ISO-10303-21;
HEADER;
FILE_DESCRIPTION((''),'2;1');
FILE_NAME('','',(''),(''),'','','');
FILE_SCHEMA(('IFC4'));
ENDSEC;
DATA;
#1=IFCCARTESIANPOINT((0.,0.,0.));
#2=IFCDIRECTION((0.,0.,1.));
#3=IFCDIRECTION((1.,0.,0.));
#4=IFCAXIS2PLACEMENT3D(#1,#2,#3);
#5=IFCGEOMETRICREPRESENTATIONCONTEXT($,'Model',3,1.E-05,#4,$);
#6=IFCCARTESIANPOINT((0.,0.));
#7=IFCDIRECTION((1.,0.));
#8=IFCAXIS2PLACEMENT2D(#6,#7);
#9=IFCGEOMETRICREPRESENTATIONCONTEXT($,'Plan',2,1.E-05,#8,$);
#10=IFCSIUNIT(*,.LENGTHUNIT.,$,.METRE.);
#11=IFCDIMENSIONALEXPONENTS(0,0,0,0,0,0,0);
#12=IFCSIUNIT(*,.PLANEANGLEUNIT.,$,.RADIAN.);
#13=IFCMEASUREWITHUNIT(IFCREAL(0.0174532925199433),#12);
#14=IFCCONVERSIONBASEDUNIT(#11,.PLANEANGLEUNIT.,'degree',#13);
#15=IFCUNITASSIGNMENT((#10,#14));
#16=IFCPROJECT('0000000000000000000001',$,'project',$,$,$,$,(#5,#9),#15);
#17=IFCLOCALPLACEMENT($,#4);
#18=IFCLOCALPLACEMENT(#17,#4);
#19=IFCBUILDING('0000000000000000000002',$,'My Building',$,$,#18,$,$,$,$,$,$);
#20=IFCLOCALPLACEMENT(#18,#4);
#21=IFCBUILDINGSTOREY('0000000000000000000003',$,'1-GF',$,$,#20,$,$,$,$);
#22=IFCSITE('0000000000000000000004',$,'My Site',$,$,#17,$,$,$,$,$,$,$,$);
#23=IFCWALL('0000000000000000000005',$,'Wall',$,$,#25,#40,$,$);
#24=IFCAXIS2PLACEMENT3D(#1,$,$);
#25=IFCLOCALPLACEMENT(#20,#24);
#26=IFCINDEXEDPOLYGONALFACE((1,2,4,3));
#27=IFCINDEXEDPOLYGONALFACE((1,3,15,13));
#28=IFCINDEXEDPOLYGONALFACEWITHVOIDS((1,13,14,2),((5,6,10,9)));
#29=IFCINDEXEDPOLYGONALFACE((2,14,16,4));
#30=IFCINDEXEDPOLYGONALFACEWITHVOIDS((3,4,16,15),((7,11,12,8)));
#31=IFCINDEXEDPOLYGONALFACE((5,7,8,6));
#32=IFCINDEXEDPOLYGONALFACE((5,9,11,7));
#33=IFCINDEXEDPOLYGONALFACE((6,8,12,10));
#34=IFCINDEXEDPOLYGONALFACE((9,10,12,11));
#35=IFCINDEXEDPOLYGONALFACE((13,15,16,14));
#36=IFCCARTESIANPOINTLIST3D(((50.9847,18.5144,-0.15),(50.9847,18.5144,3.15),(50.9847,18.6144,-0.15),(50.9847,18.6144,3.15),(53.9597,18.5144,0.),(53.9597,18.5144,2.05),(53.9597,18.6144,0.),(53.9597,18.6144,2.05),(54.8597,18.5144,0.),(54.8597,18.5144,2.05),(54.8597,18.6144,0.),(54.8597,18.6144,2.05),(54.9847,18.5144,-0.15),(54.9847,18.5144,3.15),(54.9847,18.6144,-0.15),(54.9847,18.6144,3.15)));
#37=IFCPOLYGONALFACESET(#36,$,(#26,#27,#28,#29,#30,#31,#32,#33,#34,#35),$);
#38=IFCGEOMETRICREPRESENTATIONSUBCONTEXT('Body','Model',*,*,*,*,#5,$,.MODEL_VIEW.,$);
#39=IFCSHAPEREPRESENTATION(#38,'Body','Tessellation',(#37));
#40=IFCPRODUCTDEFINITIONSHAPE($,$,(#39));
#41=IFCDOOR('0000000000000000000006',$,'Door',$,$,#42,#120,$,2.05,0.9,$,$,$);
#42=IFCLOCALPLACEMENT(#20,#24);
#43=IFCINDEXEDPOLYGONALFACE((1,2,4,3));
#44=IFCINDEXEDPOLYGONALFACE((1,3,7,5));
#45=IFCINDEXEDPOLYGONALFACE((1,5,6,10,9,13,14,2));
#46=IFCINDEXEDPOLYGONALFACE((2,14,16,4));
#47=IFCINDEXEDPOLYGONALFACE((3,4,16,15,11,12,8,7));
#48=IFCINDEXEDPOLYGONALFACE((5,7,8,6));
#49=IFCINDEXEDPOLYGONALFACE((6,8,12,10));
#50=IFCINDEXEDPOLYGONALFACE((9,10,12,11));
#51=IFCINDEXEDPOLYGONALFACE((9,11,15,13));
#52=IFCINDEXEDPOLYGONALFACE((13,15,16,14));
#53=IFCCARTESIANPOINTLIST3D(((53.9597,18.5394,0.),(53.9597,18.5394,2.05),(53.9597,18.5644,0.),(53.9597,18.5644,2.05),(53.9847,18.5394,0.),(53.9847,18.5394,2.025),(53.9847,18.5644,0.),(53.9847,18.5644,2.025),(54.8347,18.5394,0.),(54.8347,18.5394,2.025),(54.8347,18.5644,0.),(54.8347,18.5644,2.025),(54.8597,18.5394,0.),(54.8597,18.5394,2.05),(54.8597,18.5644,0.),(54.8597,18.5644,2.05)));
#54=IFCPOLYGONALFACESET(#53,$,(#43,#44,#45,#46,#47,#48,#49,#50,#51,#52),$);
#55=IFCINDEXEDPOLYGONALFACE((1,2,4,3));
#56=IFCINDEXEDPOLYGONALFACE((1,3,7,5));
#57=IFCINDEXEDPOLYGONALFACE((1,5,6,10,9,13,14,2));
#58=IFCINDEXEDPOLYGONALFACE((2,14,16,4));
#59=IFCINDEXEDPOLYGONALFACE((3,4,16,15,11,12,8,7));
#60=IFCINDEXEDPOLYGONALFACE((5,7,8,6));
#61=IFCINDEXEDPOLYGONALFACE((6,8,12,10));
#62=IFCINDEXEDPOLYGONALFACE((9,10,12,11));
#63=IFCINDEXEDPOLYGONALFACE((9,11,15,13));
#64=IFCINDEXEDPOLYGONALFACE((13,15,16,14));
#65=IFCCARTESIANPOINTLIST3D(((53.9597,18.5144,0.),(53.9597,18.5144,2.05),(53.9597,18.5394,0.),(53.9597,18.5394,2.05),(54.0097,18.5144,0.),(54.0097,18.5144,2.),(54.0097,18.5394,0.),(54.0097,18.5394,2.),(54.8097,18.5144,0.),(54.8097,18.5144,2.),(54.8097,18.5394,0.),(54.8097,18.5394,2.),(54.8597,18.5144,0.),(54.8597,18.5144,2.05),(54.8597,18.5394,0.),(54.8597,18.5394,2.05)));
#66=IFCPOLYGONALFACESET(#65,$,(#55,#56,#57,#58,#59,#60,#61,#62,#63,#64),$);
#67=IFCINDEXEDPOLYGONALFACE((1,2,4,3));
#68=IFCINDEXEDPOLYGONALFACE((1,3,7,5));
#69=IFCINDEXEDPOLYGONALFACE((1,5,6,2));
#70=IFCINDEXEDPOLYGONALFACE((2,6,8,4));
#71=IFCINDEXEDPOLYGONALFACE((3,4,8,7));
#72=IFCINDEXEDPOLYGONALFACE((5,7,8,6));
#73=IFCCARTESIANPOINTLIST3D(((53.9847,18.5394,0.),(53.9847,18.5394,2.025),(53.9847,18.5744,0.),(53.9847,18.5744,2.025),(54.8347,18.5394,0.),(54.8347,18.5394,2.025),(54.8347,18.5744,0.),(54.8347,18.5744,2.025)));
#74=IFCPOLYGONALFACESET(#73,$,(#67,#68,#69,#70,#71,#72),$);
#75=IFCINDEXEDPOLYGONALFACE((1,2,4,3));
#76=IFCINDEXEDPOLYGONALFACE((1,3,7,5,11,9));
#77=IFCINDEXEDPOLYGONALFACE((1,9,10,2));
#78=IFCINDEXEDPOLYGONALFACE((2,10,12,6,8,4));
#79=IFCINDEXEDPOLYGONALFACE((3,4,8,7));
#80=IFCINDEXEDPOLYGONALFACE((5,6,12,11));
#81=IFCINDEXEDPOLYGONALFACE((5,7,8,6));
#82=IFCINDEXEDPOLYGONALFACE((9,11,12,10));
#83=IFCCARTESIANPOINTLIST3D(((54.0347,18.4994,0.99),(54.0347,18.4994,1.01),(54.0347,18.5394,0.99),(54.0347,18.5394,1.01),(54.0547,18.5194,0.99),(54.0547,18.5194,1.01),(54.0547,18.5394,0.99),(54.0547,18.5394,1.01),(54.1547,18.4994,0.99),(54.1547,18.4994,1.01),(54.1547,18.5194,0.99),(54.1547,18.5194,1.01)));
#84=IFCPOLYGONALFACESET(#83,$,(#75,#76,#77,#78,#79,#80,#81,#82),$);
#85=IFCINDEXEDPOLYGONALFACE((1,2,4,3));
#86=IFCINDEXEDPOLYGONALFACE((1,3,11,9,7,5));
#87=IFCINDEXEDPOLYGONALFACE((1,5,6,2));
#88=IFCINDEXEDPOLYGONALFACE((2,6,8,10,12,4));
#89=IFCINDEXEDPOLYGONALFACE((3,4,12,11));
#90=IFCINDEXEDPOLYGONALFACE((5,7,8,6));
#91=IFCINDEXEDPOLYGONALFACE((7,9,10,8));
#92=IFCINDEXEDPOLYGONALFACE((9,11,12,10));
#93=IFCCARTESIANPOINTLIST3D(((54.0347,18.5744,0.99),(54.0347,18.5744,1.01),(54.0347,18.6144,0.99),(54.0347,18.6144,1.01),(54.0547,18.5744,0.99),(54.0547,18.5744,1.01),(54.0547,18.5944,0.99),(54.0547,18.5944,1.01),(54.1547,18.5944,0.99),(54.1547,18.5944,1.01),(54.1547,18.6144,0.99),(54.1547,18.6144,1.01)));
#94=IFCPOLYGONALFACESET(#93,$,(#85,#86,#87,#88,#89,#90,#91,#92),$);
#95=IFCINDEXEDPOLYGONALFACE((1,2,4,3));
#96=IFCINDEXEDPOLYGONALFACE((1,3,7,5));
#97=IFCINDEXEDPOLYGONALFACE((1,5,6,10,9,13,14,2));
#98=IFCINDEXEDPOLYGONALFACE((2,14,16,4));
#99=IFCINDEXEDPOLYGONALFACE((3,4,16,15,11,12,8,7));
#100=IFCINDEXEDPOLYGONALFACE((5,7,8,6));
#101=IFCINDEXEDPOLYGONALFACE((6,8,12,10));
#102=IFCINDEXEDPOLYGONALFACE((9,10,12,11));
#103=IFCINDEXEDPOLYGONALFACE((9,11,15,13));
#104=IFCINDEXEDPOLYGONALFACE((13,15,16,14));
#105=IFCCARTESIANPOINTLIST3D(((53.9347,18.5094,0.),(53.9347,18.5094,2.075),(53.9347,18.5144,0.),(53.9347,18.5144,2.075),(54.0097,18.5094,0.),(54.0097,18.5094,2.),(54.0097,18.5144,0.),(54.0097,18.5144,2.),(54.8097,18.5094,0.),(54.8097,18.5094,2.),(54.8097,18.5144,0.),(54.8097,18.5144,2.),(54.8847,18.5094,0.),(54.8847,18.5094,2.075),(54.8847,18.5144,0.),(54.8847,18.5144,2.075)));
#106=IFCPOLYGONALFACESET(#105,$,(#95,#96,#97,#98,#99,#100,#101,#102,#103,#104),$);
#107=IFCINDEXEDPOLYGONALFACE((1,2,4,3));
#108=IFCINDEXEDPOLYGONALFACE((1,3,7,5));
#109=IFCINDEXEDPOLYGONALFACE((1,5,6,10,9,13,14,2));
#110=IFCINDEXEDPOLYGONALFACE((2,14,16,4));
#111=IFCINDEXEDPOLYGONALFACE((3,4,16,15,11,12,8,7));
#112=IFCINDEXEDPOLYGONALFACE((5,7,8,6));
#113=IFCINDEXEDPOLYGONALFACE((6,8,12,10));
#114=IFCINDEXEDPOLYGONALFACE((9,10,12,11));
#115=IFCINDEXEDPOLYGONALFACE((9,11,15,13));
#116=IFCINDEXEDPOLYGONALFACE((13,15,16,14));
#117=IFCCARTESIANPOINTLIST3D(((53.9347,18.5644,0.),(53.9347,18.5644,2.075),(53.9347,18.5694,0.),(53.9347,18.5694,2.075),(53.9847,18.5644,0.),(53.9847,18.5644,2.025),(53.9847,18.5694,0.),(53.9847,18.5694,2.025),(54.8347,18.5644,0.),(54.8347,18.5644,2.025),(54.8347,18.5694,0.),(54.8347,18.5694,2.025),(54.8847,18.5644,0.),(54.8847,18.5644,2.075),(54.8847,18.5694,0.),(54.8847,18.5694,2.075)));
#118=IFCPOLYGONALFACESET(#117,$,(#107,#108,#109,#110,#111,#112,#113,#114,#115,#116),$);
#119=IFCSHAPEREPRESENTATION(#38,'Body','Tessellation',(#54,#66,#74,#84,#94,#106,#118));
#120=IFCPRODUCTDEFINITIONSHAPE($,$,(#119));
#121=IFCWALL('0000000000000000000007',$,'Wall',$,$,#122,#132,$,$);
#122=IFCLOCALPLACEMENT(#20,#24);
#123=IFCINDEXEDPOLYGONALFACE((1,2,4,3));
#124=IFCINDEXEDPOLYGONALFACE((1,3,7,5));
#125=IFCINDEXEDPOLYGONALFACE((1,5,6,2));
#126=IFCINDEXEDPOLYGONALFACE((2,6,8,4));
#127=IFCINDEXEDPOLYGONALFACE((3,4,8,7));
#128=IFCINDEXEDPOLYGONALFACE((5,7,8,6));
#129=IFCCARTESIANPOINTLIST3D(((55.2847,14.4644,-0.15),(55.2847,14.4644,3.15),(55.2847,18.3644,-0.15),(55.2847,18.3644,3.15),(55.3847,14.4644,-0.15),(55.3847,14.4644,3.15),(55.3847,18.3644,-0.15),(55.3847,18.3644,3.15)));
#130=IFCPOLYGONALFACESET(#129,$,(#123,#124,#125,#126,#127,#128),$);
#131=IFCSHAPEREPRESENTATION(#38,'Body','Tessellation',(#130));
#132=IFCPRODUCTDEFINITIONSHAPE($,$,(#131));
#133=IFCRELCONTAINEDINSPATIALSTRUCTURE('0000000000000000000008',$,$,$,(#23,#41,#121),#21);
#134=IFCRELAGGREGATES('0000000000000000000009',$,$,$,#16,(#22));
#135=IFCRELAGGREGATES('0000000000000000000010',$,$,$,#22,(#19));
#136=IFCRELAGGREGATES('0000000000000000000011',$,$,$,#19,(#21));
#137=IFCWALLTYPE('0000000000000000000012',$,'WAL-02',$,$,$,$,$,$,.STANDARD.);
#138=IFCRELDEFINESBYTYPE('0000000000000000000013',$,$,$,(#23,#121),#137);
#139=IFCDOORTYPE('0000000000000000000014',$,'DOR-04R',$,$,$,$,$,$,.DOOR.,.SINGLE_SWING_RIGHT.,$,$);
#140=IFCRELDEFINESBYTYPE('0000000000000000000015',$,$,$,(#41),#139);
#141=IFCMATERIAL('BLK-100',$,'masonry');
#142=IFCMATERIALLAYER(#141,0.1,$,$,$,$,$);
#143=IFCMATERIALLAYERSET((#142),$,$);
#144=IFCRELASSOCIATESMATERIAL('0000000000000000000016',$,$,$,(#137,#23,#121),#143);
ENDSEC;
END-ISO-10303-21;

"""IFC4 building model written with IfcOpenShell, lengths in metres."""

from ifc_helpers import new_model, entity, si_unit, converted_unit, frame, origin_with_axes, origin_2d_with_axis, place, context, subcontext, project, spatial, line, indexed_curve, outline, extrude, shape, source, transform, mapped, material, layer, layer_set, layer_usage, type_object, type_shapes, element, fill, save


model = new_model("IFC4")

# Units and contexts
model_context = context("Model", 3, precision=1e-05, world=origin_with_axes())
plan_context = context("Plan", 2, precision=1e-05, world=origin_2d_with_axis())
body_context_1 = subcontext(model_context, "Body", "Model", "MODEL_VIEW")
body_context_2 = subcontext(plan_context, "Body", "Plan", "PLAN_VIEW")
ifc_project = project(units=[si_unit("LENGTHUNIT", "METRE"), converted_unit("PLANEANGLEUNIT", "degree", entity("IfcReal", 0.0174532925199433), si_unit("PLANEANGLEUNIT", "RADIAN"), dimensions=[0, 0, 0, 0, 0, 0, 0])], contexts=[model_context, plan_context])

# Site, building, storey
site_placement = place(None, origin_with_axes())
site = spatial("IfcSite", under=ifc_project, at=site_placement, Name="My Site")
building_placement = place(site_placement, origin_with_axes())
building = spatial("IfcBuilding", under=site, at=building_placement, Name="My Building")
storey_placement = place(building_placement, origin_with_axes())
storey = spatial("IfcBuildingStorey", under=building, at=storey_placement, Name="1-GF")

# Wall, opening, door
ifc_material_1 = material(Name="BLK-100", Category="masonry")
ifc_layer_1 = layer(ifc_material_1, 0.1)
ifc_layer_set_1 = layer_set([ifc_layer_1])
ifc_layer_usage_1 = layer_usage(ifc_layer_set_1, "AXIS2", "POSITIVE", 0.0)
wall_type_1 = type_object("IfcWallType", Name="WAL-02", PredefinedType="STANDARD", material=ifc_layer_set_1)
wall_1_placement = place(storey_placement, frame((50.9847, 18.5144, -0.15), z_axis=(0.0, 0.0, 1.0), x_axis=(1.0, -0.000001, 0.0)))
wall_1 = element("IfcWall", 1, at=wall_1_placement, inside=storey, type_object=wall_type_1, material=ifc_layer_usage_1, Name="Wall", context=body_context_1, shape_type="SweptSolid", body=[
    extrude(outline(indexed_curve([(0.0, 0.0), (0.0, 0.1), (4.0, 0.1), (4.0, 0.0), (0.0, 0.0)], self_intersect=False)), origin_with_axes(), (0.0, 0.0, 1.0), 3.3),
])
shared_shape_1 = source(origin_with_axes(), body_context_1, "Body", "SweptSolid", [
    extrude(outline(indexed_curve([(0.0, 0.0), (0.9, 0.0), (0.9, 2.05), (0.0, 2.05)], segments=[line(1, 2, 3, 4, 1)])), frame((0.0, -0.6, 0.0), z_axis=(0.0, -1.0, 0.0), x_axis=(1.0, 0.0, 0.0)), (0.0, 0.0, -1.0), 1.2),
])
opening_1_placement = place(wall_1_placement, frame((2.975, 0.0, 0.15), z_axis=(0.0, 0.0, 1.0), x_axis=(1.0, 0.0, 0.0)))
opening_1 = element("IfcOpeningElement", 2, at=opening_1_placement, cuts=wall_1, PredefinedType="OPENING", context=body_context_1, shape_type="MappedRepresentation", body=[
    mapped(shared_shape_1, transform((0.0, 0.0, 0.0), x_axis=(1.0, 0.0, 0.0), y_axis=(0.0, 1.0, 0.0), z_axis=(0.0, 0.0, 1.0), scale=1.0)),
])
door_type_1 = type_object("IfcDoorType", Name="DOR-04R", OperationType="SINGLE_SWING_RIGHT", PredefinedType="DOOR")
shared_shape_2 = source(origin_with_axes(), body_context_1, "Body", "SweptSolid", [
    extrude(outline(indexed_curve([(0.0, 0.0), (0.0, 2.05), (0.9, 2.05), (0.9, 0.0), (0.875, 0.0), (0.875, 2.025), (0.025, 2.025), (0.025, 0.0)], segments=[line(1, 2, 3, 4, 5, 6, 7, 8, 1)])), frame((0.0, 0.025, 0.0), z_axis=(0.0, -1.0, 0.0), x_axis=(1.0, 0.0, 0.0)), (0.0, 0.0, -1.0), 0.025),
    extrude(outline(indexed_curve([(0.0, 0.0), (0.0, 2.05), (0.9, 2.05), (0.9, 0.0), (0.85, 0.0), (0.85, 2.0), (0.05, 2.0), (0.05, 0.0)], segments=[line(1, 2, 3, 4, 5, 6, 7, 8, 1)])), frame((0.0, 0.0, 0.0), z_axis=(0.0, -1.0, 0.0), x_axis=(1.0, 0.0, 0.0)), (0.0, 0.0, -1.0), 0.025),
    extrude(outline(indexed_curve([(0.0, 0.0), (0.85, 0.0), (0.85, 0.035), (0.0, 0.035)], segments=[line(1, 2, 3, 4, 1)])), frame((0.025, 0.025, 0.0), z_axis=(0.0, 0.0, 1.0), x_axis=(1.0, 0.0, 0.0)), (0.0, 0.0, 1.0), 2.025),
    extrude(outline(indexed_curve([(0.0, 0.0), (0.0, -0.04), (0.12, -0.04), (0.12, -0.02), (0.02, -0.02), (0.02, 0.0)], segments=[line(1, 2, 3, 4, 5, 6, 1)])), frame((0.075, 0.025, 0.99), z_axis=(0.0, 0.0, 1.0), x_axis=(1.0, 0.0, 0.0)), (0.0, 0.0, 1.0), 0.02),
    extrude(outline(indexed_curve([(0.0, 0.0), (0.0, 0.04), (0.12, 0.04), (0.12, 0.02), (0.02, 0.02), (0.02, 0.0)], segments=[line(1, 2, 3, 4, 5, 6, 1)])), frame((0.075, 0.06, 0.99), z_axis=(0.0, 0.0, 1.0), x_axis=(1.0, 0.0, 0.0)), (0.0, 0.0, 1.0), 0.02),
    extrude(outline(indexed_curve([(0.0, 0.0), (0.0, 2.075), (0.95, 2.075), (0.95, 0.0), (0.875, 0.0), (0.875, 2.0), (0.075, 2.0), (0.075, 0.0)], segments=[line(1, 2, 3, 4, 5, 6, 7, 8, 1)])), frame((-0.025, -0.005, 0.0), z_axis=(0.0, -1.0, 0.0), x_axis=(1.0, 0.0, 0.0)), (0.0, 0.0, -1.0), 0.005),
    extrude(outline(indexed_curve([(0.0, 0.0), (0.0, 2.075), (0.95, 2.075), (0.95, 0.0), (0.9, 0.0), (0.9, 2.025), (0.05, 2.025), (0.05, 0.0)], segments=[line(1, 2, 3, 4, 5, 6, 7, 8, 1)])), frame((-0.025, 0.05, 0.0), z_axis=(0.0, -1.0, 0.0), x_axis=(1.0, 0.0, 0.0)), (0.0, 0.0, -1.0), 0.005),
])
shared_shape_3 = source(origin_with_axes(), body_context_2, "Body", "Curve2D", [
    entity("IfcIndexedPolyCurve", entity("IfcCartesianPointList2D", [[0.0, 0.0], [0.0, 0.05], [0.025, 0.05], [0.025, 0.025], [0.05, 0.025], [0.05, 0.0]]), [entity("IfcLineIndex", [1, 2, 3, 4, 5, 6, 1])]),
    entity("IfcIndexedPolyCurve", entity("IfcCartesianPointList2D", [[0.9, 0.0], [0.9, 0.05], [0.875, 0.05], [0.875, 0.025], [0.85, 0.025], [0.85, 0.0]]), [entity("IfcLineIndex", [1, 2, 3, 4, 5, 6, 1])]),
    entity("IfcTrimmedCurve", entity("IfcEllipse", entity("IfcAxis2Placement2D", entity("IfcCartesianPoint", [0.84, 0.05]), entity("IfcDirection", [1.0, 0.0])), 0.815, 0.85), [entity("IfcCartesianPoint", [0.84, 0.9])], [entity("IfcCartesianPoint", [0.025, 0.05])], True, "CARTESIAN"),
    entity("IfcIndexedPolyCurve", entity("IfcCartesianPointList2D", [[0.875, 0.05], [0.84, 0.05], [0.84, 0.9], [0.875, 0.9]]), [entity("IfcLineIndex", [1, 2, 3, 4, 1])]),
])
type_shapes(door_type_1, [shared_shape_2, shared_shape_3])
door_1_placement = place(opening_1_placement, frame((0.0, 0.0, 0.0), z_axis=(0.0, 0.0, 1.0), x_axis=(1.0, 0.0, 0.0)))
door_1 = element("IfcDoor", 3, at=door_1_placement, inside=storey, type_object=door_type_1, Name="Door", OverallHeight=2.05, OverallWidth=0.9, shapes=[
    shape(body_context_1, "Body", "MappedRepresentation", [mapped(shared_shape_2, transform((0.0, 0.0, 0.0), x_axis=(1.0, 0.0, 0.0), y_axis=(0.0, 1.0, 0.0), z_axis=(0.0, 0.0, 1.0), scale=1.0))]),
    shape(body_context_2, "Body", "MappedRepresentation", [mapped(shared_shape_3, transform((0.0, 0.0, 0.0), x_axis=(1.0, 0.0, 0.0), y_axis=(0.0, 1.0, 0.0), z_axis=(0.0, 0.0, 1.0), scale=1.0))]),
])
fill(opening_1, door_1)

# Wall
ifc_layer_usage_2 = layer_usage(ifc_layer_set_1, "AXIS2", "POSITIVE", 0.0)
wall_2_placement = place(storey_placement, frame((55.3847, 14.4644, -0.15), z_axis=(0.0, 0.0, 1.0), x_axis=(0.0, 1.0, 0.0)))
element("IfcWall", 4, at=wall_2_placement, inside=storey, type_object=wall_type_1, material=ifc_layer_usage_2, Name="Wall", context=body_context_1, shape_type="SweptSolid", body=[
    extrude(outline(indexed_curve([(0.0, 0.0), (0.0, 0.1), (3.9, 0.1), (3.9, 0.0), (0.0, 0.0)], self_intersect=False)), origin_with_axes(), (0.0, 0.0, 1.0), 3.3),
])

save(model, "model.ifc")
